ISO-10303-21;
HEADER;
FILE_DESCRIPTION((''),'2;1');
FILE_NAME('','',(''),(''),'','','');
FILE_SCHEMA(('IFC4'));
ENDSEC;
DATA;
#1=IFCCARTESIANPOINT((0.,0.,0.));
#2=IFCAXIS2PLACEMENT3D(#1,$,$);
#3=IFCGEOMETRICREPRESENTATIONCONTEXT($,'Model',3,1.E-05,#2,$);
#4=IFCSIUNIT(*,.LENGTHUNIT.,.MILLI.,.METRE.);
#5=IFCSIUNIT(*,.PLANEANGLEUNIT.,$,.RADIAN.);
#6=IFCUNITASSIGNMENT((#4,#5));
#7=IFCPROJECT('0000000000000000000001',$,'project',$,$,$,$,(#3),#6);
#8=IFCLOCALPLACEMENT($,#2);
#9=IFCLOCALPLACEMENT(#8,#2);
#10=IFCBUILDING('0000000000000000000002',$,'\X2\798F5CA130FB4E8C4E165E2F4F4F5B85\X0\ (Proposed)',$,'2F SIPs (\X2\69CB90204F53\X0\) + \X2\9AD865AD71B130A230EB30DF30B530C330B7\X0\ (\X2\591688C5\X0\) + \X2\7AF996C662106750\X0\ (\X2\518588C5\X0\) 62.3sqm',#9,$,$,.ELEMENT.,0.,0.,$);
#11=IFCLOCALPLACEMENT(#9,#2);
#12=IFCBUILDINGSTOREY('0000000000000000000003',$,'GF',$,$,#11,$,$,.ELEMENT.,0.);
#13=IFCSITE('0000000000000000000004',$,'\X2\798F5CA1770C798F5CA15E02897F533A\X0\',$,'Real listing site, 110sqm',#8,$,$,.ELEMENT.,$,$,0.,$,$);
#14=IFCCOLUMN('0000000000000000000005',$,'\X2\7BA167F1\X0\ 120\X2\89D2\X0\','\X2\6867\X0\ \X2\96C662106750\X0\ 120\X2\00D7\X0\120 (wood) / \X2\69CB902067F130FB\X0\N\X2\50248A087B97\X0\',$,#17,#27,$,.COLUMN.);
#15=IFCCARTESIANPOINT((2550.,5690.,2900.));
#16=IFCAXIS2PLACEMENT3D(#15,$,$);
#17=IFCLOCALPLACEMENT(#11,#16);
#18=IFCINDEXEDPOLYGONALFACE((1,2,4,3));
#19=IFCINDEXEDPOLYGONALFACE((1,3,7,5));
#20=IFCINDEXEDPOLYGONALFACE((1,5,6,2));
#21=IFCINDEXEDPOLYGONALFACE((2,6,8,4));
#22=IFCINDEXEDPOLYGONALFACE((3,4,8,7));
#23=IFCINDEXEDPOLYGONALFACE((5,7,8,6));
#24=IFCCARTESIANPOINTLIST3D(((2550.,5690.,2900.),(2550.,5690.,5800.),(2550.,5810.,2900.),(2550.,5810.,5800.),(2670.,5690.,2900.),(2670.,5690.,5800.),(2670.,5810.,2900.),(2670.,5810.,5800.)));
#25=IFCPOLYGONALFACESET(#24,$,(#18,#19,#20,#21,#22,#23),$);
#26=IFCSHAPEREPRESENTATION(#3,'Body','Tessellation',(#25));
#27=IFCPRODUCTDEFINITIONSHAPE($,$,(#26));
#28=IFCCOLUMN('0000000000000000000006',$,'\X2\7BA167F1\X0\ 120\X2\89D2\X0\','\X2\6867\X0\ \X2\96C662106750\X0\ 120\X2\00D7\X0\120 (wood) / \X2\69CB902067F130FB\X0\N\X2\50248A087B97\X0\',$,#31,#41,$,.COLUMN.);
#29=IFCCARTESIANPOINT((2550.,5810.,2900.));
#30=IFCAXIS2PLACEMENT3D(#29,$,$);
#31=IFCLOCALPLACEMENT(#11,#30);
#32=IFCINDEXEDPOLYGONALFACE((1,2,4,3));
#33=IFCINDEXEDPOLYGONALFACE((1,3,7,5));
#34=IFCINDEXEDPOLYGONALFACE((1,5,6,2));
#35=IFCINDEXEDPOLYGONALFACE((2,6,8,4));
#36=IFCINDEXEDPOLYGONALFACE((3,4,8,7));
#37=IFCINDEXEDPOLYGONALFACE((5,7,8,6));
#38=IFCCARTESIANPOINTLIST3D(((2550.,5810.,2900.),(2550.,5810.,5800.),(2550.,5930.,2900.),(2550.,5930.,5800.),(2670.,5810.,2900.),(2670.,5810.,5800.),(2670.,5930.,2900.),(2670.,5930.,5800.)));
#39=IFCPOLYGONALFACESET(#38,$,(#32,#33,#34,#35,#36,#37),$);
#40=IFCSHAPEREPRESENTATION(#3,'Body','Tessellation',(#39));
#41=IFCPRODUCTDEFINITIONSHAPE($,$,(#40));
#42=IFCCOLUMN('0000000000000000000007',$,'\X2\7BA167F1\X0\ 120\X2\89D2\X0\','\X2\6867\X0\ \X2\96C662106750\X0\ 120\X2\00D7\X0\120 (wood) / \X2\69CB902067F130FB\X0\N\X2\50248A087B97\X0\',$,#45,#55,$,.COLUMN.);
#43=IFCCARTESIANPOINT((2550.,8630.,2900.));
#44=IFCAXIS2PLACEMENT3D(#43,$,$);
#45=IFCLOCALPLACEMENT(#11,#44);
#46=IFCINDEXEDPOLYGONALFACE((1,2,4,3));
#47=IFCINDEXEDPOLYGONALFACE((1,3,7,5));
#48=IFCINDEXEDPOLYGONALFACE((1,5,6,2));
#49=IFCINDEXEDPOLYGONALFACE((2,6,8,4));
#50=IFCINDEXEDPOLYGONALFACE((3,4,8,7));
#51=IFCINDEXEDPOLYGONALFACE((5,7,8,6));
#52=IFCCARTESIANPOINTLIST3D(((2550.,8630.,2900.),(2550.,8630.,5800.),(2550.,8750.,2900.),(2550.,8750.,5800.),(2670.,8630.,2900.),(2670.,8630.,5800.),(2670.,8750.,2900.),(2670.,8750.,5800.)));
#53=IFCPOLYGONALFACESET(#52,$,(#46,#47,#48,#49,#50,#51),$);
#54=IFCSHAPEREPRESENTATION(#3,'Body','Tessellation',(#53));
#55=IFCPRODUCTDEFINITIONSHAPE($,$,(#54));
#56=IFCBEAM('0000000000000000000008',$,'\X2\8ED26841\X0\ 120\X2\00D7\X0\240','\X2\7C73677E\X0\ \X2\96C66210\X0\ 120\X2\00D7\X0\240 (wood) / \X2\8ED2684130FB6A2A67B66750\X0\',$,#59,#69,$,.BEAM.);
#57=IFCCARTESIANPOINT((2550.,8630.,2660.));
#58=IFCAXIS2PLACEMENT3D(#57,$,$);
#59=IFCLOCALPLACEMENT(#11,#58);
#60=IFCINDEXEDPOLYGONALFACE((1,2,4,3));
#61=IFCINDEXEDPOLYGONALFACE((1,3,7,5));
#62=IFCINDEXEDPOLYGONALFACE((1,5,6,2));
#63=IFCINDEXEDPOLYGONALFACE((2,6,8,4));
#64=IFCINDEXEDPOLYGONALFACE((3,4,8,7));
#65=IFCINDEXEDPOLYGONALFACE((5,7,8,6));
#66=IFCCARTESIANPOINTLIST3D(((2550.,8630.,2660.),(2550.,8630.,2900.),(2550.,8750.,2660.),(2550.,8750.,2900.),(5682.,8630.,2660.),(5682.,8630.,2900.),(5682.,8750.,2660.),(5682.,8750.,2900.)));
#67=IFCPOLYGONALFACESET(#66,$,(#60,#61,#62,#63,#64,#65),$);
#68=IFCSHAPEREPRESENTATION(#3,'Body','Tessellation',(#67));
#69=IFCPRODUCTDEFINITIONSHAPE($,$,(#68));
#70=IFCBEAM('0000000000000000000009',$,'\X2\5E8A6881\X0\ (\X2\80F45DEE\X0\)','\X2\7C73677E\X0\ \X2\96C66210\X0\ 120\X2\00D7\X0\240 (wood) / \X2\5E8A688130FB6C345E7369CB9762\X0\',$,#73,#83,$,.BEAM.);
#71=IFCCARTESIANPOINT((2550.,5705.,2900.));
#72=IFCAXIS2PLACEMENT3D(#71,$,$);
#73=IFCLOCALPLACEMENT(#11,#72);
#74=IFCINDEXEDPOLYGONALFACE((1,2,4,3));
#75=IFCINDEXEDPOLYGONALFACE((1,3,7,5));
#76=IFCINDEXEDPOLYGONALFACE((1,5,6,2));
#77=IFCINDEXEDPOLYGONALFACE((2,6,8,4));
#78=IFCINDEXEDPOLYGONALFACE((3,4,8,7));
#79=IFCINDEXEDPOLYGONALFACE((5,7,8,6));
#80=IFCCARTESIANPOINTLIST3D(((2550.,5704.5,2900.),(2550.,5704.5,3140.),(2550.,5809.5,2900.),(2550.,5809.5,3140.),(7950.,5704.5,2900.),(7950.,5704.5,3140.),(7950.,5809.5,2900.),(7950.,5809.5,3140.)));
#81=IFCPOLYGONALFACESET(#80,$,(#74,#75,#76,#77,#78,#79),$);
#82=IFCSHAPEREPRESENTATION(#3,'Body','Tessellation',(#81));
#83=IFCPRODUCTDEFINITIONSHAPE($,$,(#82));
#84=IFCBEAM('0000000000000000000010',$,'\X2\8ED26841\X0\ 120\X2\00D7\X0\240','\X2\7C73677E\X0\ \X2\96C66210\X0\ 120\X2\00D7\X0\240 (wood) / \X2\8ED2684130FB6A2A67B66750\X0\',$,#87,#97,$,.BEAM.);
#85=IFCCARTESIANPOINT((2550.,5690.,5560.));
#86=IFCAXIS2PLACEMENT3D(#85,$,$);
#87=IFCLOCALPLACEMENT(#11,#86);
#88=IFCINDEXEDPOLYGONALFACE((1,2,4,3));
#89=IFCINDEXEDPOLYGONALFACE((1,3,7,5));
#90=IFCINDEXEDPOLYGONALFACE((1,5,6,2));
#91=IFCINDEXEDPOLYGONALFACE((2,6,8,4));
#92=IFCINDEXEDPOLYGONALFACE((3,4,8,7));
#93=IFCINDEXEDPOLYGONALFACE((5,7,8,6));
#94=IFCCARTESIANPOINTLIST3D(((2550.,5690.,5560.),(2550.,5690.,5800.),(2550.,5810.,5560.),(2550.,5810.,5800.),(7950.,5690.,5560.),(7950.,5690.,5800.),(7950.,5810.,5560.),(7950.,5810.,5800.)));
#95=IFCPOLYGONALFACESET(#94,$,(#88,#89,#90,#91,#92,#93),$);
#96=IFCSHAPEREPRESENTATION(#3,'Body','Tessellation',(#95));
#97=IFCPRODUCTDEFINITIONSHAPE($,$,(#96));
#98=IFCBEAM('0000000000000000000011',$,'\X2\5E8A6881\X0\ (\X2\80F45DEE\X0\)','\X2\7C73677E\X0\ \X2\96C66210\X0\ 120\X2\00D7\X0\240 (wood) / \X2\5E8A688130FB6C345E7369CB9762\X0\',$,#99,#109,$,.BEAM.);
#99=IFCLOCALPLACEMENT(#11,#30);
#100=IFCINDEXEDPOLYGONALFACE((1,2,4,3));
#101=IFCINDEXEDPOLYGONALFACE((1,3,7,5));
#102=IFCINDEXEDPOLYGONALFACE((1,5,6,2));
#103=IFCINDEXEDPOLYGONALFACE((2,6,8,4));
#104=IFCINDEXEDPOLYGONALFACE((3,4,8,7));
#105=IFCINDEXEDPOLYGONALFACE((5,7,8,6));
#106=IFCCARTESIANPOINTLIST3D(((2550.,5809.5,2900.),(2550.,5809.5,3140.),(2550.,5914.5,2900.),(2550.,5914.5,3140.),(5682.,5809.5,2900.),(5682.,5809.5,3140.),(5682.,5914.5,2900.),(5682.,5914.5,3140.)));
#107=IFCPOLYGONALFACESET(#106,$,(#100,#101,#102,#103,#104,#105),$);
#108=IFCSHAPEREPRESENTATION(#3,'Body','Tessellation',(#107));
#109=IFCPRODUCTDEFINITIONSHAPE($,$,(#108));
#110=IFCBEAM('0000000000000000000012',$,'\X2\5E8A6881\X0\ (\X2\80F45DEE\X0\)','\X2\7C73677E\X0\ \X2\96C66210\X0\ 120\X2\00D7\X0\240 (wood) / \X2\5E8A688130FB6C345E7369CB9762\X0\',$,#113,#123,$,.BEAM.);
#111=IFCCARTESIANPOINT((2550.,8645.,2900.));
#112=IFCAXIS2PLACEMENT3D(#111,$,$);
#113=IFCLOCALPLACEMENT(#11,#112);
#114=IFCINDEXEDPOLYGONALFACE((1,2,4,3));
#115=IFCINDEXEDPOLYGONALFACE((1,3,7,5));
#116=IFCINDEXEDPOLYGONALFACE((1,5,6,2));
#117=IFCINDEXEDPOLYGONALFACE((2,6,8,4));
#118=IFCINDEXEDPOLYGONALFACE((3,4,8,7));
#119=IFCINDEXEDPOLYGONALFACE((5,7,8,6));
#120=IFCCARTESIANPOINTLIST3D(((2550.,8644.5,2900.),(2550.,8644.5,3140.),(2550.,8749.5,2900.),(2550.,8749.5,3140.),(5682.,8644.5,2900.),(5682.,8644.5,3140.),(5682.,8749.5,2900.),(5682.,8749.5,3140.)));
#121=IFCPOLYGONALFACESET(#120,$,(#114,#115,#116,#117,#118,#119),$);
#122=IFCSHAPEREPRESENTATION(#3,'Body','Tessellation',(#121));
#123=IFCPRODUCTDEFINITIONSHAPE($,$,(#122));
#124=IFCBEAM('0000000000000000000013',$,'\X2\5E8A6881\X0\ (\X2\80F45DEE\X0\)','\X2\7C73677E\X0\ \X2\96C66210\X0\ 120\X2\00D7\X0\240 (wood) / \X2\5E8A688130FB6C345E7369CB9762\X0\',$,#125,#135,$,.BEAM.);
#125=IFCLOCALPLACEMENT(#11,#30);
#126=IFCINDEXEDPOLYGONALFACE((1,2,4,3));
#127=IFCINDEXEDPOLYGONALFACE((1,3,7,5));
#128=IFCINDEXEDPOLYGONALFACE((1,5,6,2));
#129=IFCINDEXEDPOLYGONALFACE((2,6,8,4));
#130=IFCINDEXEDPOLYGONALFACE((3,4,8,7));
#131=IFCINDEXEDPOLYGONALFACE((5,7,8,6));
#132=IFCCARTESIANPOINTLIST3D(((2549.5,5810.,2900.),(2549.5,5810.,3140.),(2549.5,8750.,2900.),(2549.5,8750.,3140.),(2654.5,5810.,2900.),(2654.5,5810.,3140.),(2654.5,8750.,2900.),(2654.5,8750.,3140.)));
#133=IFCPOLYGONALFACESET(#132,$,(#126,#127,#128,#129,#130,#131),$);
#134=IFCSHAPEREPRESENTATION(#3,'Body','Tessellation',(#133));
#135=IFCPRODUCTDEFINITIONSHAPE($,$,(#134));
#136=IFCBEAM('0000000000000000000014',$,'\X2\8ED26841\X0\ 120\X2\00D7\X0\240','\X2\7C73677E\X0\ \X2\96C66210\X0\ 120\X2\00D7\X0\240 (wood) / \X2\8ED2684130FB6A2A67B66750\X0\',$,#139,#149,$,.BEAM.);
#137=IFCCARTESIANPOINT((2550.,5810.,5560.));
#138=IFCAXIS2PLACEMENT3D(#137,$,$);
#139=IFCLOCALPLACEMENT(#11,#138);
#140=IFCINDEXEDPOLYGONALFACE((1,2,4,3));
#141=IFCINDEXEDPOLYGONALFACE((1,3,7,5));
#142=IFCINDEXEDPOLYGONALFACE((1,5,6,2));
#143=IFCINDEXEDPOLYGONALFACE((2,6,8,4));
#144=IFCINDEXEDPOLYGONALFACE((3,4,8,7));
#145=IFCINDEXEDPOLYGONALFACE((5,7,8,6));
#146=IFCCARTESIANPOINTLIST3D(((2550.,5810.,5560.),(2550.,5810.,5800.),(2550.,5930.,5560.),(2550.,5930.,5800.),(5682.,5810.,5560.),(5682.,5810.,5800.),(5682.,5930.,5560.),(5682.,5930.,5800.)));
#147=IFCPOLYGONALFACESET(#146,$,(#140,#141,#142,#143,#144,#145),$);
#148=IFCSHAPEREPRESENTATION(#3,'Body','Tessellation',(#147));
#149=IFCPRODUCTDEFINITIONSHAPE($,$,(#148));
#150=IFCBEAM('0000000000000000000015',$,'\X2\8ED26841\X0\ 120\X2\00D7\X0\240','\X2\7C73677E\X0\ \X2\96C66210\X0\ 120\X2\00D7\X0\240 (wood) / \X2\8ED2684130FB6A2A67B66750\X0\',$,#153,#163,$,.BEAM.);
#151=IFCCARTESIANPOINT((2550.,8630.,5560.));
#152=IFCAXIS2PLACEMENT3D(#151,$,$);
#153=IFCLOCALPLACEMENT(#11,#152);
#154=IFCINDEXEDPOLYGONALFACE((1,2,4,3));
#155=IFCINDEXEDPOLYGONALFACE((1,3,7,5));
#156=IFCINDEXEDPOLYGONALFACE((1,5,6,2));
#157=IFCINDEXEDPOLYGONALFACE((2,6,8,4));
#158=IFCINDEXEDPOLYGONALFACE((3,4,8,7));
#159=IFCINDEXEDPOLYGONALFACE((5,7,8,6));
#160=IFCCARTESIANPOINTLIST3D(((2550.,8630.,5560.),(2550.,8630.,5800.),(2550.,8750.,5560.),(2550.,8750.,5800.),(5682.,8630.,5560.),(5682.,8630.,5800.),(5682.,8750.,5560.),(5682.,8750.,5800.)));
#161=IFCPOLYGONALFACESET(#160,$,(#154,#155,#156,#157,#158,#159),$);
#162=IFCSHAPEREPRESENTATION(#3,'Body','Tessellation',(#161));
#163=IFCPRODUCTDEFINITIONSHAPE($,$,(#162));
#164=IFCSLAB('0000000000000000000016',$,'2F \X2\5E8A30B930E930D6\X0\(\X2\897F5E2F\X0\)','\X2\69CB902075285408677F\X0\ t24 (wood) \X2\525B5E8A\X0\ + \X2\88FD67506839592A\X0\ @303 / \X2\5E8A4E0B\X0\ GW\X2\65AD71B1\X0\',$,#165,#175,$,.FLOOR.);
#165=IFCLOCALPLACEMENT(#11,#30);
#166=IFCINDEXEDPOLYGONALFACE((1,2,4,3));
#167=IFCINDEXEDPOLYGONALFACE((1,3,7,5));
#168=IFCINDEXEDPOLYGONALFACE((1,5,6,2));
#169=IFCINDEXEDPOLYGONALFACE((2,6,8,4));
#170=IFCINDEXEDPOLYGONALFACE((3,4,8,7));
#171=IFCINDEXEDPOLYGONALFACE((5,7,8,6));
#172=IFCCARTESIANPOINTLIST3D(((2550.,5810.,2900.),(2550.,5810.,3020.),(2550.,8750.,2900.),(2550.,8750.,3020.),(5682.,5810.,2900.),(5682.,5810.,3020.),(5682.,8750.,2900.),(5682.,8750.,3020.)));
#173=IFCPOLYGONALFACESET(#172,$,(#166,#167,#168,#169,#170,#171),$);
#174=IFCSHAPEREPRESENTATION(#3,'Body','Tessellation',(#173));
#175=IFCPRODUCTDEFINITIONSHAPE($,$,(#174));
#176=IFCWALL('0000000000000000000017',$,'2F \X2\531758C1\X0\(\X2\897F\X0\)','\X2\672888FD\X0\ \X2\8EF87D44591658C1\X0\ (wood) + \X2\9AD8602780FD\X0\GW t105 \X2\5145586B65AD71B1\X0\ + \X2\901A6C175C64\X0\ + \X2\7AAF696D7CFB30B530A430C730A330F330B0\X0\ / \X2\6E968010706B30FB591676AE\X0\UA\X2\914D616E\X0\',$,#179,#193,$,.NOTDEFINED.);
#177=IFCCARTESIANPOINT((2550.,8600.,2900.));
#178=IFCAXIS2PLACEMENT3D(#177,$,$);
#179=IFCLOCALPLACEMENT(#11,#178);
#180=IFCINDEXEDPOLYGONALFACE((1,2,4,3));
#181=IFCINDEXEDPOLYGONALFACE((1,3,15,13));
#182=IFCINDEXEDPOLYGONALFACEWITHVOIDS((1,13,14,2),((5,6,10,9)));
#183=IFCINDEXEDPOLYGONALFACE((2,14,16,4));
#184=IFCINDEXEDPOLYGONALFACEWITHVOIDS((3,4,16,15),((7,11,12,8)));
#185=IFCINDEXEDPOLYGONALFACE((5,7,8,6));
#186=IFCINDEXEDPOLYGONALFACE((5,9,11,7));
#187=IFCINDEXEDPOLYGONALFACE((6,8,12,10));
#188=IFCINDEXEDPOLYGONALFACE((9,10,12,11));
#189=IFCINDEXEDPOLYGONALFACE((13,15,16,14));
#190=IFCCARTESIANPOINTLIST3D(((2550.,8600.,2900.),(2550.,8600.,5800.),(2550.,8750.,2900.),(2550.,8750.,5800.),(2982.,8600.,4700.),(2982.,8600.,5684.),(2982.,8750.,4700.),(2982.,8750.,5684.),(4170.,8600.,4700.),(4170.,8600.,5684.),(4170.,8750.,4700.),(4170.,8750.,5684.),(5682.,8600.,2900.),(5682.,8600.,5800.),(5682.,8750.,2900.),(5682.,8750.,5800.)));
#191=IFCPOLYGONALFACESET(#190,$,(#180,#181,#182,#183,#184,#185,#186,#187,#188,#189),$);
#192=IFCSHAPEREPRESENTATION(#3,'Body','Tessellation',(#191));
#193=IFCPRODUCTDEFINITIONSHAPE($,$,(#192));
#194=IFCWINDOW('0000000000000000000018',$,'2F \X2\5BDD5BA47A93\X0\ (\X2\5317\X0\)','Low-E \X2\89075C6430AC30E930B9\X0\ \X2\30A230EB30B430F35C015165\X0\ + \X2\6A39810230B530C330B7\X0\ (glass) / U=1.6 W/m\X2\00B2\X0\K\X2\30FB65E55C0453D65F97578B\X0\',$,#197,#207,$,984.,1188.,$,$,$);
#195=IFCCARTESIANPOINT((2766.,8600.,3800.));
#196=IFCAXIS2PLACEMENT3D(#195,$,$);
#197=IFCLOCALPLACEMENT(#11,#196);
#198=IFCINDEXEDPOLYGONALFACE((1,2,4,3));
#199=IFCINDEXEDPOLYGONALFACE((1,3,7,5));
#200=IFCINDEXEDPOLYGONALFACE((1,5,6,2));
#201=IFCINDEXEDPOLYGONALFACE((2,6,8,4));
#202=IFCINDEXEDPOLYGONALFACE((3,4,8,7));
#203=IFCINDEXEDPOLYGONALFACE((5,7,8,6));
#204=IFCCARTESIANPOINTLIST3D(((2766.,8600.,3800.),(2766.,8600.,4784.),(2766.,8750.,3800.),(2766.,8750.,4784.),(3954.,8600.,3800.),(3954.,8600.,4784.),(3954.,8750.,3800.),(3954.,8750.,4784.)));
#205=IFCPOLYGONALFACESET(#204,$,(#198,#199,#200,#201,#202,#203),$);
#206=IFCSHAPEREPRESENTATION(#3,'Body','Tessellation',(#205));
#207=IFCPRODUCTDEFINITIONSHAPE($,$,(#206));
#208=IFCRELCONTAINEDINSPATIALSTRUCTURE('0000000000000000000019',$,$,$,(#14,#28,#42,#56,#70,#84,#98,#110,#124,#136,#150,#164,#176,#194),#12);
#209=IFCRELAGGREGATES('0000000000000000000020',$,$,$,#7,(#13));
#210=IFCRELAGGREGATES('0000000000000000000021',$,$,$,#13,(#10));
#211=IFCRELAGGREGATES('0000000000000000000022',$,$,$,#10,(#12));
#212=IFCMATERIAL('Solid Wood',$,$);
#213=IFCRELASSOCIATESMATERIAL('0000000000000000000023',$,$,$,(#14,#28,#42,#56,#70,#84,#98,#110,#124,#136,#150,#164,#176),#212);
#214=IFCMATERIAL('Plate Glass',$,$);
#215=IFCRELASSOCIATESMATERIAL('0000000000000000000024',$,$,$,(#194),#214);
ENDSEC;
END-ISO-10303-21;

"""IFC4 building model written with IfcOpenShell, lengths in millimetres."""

from ifc_helpers import new_model, si_unit, frame, frame_2d, origin, place, context, project, spatial, rectangle, extrude, material, element, fill, save


model = new_model("IFC4")

# Units and contexts
model_context = context("Model", 3, precision=1e-05, world=origin())
ifc_project = project(units=[si_unit("LENGTHUNIT", "METRE", prefix="MILLI"), si_unit("PLANEANGLEUNIT", "RADIAN")], contexts=[model_context])

# Site, building, storey
site_placement = place(None, origin())
site = spatial("IfcSite", under=ifc_project, at=site_placement, Name="福岡県福岡市西区", ObjectType="Real listing site, 110sqm", CompositionType="ELEMENT", RefElevation=0.0)
building_placement = place(site_placement, origin())
building = spatial("IfcBuilding", under=site, at=building_placement, Name="福岡・二世帯住宅 (Proposed)", ObjectType="2F SIPs (構造体) + 高断熱アルミサッシ (外装) + 竹集成材 (内装) 62.3sqm", CompositionType="ELEMENT", ElevationOfRefHeight=0.0, ElevationOfTerrain=0.0)
storey_placement = place(building_placement, origin())
storey = spatial("IfcBuildingStorey", under=building, at=storey_placement, Name="GF", CompositionType="ELEMENT", Elevation=0.0)

# Columns
ifc_material_1 = material(Name="Solid Wood")
column_1_placement = place(storey_placement, frame((2550.0, 5690.0, 2900.0)))
element("IfcColumn", 1, at=column_1_placement, inside=storey, material=ifc_material_1, Name="管柱 120角", Description="桧 集成材 120×120 (wood) / 構造柱・N値計算", PredefinedType="COLUMN", context=model_context, shape_type="SweptSolid", body=[
    extrude(rectangle(XDim=120.0, YDim=120.0, at=frame_2d((60.0, 60.0))), frame((2550.0, 5690.0, 2900.0)), (0.0, 0.0, 1.0), 2900.0),
])
column_2_placement = place(storey_placement, frame((2550.0, 5810.0, 2900.0)))
element("IfcColumn", 2, at=column_2_placement, inside=storey, material=ifc_material_1, Name="管柱 120角", Description="桧 集成材 120×120 (wood) / 構造柱・N値計算", PredefinedType="COLUMN", context=model_context, shape_type="SweptSolid", body=[
    extrude(rectangle(XDim=120.0, YDim=120.0, at=frame_2d((60.0, 60.0))), frame((2550.0, 5810.0, 2900.0)), (0.0, 0.0, 1.0), 2900.0),
])
column_3_placement = place(storey_placement, frame((2550.0, 8630.0, 2900.0)))
element("IfcColumn", 3, at=column_3_placement, inside=storey, material=ifc_material_1, Name="管柱 120角", Description="桧 集成材 120×120 (wood) / 構造柱・N値計算", PredefinedType="COLUMN", context=model_context, shape_type="SweptSolid", body=[
    extrude(rectangle(XDim=120.0, YDim=120.0, at=frame_2d((60.0, 60.0))), frame((2550.0, 8630.0, 2900.0)), (0.0, 0.0, 1.0), 2900.0),
])

# Beams
beam_1_placement = place(storey_placement, frame((2550.0, 8630.0, 2660.0)))
element("IfcBeam", 4, at=beam_1_placement, inside=storey, material=ifc_material_1, Name="軒桁 120×240", Description="米松 集成 120×240 (wood) / 軒桁・横架材", PredefinedType="BEAM", context=model_context, shape_type="SweptSolid", body=[
    extrude(rectangle(XDim=3132.0, YDim=120.0, at=frame_2d((1566.0, 60.0))), frame((2550.0, 8630.0, 2660.0)), (0.0, 0.0, 1.0), 240.0),
])
beam_2_placement = place(storey_placement, frame((2550.0, 5705.0, 2900.0)))
element("IfcBeam", 5, at=beam_2_placement, inside=storey, material=ifc_material_1, Name="床梁 (胴差)", Description="米松 集成 120×240 (wood) / 床梁・水平構面", PredefinedType="BEAM", context=model_context, shape_type="SweptSolid", body=[
    extrude(rectangle(XDim=5400.0, YDim=105.0, at=frame_2d((2700.0, 52.0))), frame((2550.0, 5705.0, 2900.0)), (0.0, 0.0, 1.0), 240.0),
])
beam_3_placement = place(storey_placement, frame((2550.0, 5690.0, 5560.0)))
element("IfcBeam", 6, at=beam_3_placement, inside=storey, material=ifc_material_1, Name="軒桁 120×240", Description="米松 集成 120×240 (wood) / 軒桁・横架材", PredefinedType="BEAM", context=model_context, shape_type="SweptSolid", body=[
    extrude(rectangle(XDim=5400.0, YDim=120.0, at=frame_2d((2700.0, 60.0))), frame((2550.0, 5690.0, 5560.0)), (0.0, 0.0, 1.0), 240.0),
])
beam_4_placement = place(storey_placement, frame((2550.0, 5810.0, 2900.0)))
element("IfcBeam", 7, at=beam_4_placement, inside=storey, material=ifc_material_1, Name="床梁 (胴差)", Description="米松 集成 120×240 (wood) / 床梁・水平構面", PredefinedType="BEAM", context=model_context, shape_type="SweptSolid", body=[
    extrude(rectangle(XDim=3132.0, YDim=105.0, at=frame_2d((1566.0, 52.0))), frame((2550.0, 5810.0, 2900.0)), (0.0, 0.0, 1.0), 240.0),
])
beam_5_placement = place(storey_placement, frame((2550.0, 8645.0, 2900.0)))
element("IfcBeam", 8, at=beam_5_placement, inside=storey, material=ifc_material_1, Name="床梁 (胴差)", Description="米松 集成 120×240 (wood) / 床梁・水平構面", PredefinedType="BEAM", context=model_context, shape_type="SweptSolid", body=[
    extrude(rectangle(XDim=3132.0, YDim=105.0, at=frame_2d((1566.0, 52.0))), frame((2550.0, 8645.0, 2900.0)), (0.0, 0.0, 1.0), 240.0),
])
beam_6_placement = place(storey_placement, frame((2550.0, 5810.0, 2900.0)))
element("IfcBeam", 9, at=beam_6_placement, inside=storey, material=ifc_material_1, Name="床梁 (胴差)", Description="米松 集成 120×240 (wood) / 床梁・水平構面", PredefinedType="BEAM", context=model_context, shape_type="SweptSolid", body=[
    extrude(rectangle(XDim=105.0, YDim=2940.0, at=frame_2d((52.0, 1470.0))), frame((2550.0, 5810.0, 2900.0)), (0.0, 0.0, 1.0), 240.0),
])
beam_7_placement = place(storey_placement, frame((2550.0, 5810.0, 5560.0)))
element("IfcBeam", 10, at=beam_7_placement, inside=storey, material=ifc_material_1, Name="軒桁 120×240", Description="米松 集成 120×240 (wood) / 軒桁・横架材", PredefinedType="BEAM", context=model_context, shape_type="SweptSolid", body=[
    extrude(rectangle(XDim=3132.0, YDim=120.0, at=frame_2d((1566.0, 60.0))), frame((2550.0, 5810.0, 5560.0)), (0.0, 0.0, 1.0), 240.0),
])
beam_8_placement = place(storey_placement, frame((2550.0, 8630.0, 5560.0)))
element("IfcBeam", 11, at=beam_8_placement, inside=storey, material=ifc_material_1, Name="軒桁 120×240", Description="米松 集成 120×240 (wood) / 軒桁・横架材", PredefinedType="BEAM", context=model_context, shape_type="SweptSolid", body=[
    extrude(rectangle(XDim=3132.0, YDim=120.0, at=frame_2d((1566.0, 60.0))), frame((2550.0, 8630.0, 5560.0)), (0.0, 0.0, 1.0), 240.0),
])

# Slab
slab_placement = place(storey_placement, frame((2550.0, 5810.0, 2900.0)))
element("IfcSlab", 12, at=slab_placement, inside=storey, material=ifc_material_1, Name="2F 床スラブ(西帯)", Description="構造用合板 t24 (wood) 剛床 + 製材根太 @303 / 床下 GW断熱", PredefinedType="FLOOR", context=model_context, shape_type="SweptSolid", body=[
    extrude(rectangle(XDim=3132.0, YDim=2940.0, at=frame_2d((1566.0, 1470.0))), frame((2550.0, 5810.0, 2900.0)), (0.0, 0.0, 1.0), 120.0),
])

# Wall, opening, window
wall_1_placement = place(storey_placement, frame((2550.0, 8600.0, 2900.0)))
wall_1 = element("IfcWall", 13, at=wall_1_placement, inside=storey, material=ifc_material_1, Name="2F 北壁(西)", Description="木製 軸組外壁 (wood) + 高性能GW t105 充填断熱 + 通気層 + 窯業系サイディング / 準耐火・外皮UA配慮", PredefinedType="NOTDEFINED", context=model_context, shape_type="SweptSolid", body=[
    extrude(rectangle(XDim=3132.0, YDim=150.0, at=frame_2d((1566.0, 75.0))), frame((2550.0, 8600.0, 2900.0)), (0.0, 0.0, 1.0), 2900.0),
])
opening_placement = place(storey_placement, frame((2766.0, 8600.0, 3800.0)))
opening = element("IfcOpeningElement", 14, at=opening_placement, cuts=wall_1, PredefinedType="NOTDEFINED", context=model_context, shape_type="SweptSolid", body=[
    extrude(rectangle(XDim=1188.0, YDim=150.0, at=frame_2d((594.0, 75.0))), frame((2766.0, 8600.0, 3800.0)), (0.0, 0.0, 1.0), 984.0),
])
ifc_material_2 = material(Name="Plate Glass")
window_placement = place(storey_placement, frame((2766.0, 8600.0, 3800.0)))
window = element("IfcWindow", 15, at=window_placement, inside=storey, material=ifc_material_2, Name="2F 寝室窓 (北)", Description="Low-E 複層ガラス アルゴン封入 + 樹脂サッシ (glass) / U=1.6 W/m²K・日射取得型", OverallHeight=984.0, OverallWidth=1188.0, context=model_context, shape_type="SweptSolid", body=[
    extrude(rectangle(XDim=1188.0, YDim=150.0, at=frame_2d((594.0, 75.0))), frame((2766.0, 8600.0, 3800.0)), (0.0, 0.0, 1.0), 984.0),
])
fill(opening, window)

save(model, "model.ifc")
